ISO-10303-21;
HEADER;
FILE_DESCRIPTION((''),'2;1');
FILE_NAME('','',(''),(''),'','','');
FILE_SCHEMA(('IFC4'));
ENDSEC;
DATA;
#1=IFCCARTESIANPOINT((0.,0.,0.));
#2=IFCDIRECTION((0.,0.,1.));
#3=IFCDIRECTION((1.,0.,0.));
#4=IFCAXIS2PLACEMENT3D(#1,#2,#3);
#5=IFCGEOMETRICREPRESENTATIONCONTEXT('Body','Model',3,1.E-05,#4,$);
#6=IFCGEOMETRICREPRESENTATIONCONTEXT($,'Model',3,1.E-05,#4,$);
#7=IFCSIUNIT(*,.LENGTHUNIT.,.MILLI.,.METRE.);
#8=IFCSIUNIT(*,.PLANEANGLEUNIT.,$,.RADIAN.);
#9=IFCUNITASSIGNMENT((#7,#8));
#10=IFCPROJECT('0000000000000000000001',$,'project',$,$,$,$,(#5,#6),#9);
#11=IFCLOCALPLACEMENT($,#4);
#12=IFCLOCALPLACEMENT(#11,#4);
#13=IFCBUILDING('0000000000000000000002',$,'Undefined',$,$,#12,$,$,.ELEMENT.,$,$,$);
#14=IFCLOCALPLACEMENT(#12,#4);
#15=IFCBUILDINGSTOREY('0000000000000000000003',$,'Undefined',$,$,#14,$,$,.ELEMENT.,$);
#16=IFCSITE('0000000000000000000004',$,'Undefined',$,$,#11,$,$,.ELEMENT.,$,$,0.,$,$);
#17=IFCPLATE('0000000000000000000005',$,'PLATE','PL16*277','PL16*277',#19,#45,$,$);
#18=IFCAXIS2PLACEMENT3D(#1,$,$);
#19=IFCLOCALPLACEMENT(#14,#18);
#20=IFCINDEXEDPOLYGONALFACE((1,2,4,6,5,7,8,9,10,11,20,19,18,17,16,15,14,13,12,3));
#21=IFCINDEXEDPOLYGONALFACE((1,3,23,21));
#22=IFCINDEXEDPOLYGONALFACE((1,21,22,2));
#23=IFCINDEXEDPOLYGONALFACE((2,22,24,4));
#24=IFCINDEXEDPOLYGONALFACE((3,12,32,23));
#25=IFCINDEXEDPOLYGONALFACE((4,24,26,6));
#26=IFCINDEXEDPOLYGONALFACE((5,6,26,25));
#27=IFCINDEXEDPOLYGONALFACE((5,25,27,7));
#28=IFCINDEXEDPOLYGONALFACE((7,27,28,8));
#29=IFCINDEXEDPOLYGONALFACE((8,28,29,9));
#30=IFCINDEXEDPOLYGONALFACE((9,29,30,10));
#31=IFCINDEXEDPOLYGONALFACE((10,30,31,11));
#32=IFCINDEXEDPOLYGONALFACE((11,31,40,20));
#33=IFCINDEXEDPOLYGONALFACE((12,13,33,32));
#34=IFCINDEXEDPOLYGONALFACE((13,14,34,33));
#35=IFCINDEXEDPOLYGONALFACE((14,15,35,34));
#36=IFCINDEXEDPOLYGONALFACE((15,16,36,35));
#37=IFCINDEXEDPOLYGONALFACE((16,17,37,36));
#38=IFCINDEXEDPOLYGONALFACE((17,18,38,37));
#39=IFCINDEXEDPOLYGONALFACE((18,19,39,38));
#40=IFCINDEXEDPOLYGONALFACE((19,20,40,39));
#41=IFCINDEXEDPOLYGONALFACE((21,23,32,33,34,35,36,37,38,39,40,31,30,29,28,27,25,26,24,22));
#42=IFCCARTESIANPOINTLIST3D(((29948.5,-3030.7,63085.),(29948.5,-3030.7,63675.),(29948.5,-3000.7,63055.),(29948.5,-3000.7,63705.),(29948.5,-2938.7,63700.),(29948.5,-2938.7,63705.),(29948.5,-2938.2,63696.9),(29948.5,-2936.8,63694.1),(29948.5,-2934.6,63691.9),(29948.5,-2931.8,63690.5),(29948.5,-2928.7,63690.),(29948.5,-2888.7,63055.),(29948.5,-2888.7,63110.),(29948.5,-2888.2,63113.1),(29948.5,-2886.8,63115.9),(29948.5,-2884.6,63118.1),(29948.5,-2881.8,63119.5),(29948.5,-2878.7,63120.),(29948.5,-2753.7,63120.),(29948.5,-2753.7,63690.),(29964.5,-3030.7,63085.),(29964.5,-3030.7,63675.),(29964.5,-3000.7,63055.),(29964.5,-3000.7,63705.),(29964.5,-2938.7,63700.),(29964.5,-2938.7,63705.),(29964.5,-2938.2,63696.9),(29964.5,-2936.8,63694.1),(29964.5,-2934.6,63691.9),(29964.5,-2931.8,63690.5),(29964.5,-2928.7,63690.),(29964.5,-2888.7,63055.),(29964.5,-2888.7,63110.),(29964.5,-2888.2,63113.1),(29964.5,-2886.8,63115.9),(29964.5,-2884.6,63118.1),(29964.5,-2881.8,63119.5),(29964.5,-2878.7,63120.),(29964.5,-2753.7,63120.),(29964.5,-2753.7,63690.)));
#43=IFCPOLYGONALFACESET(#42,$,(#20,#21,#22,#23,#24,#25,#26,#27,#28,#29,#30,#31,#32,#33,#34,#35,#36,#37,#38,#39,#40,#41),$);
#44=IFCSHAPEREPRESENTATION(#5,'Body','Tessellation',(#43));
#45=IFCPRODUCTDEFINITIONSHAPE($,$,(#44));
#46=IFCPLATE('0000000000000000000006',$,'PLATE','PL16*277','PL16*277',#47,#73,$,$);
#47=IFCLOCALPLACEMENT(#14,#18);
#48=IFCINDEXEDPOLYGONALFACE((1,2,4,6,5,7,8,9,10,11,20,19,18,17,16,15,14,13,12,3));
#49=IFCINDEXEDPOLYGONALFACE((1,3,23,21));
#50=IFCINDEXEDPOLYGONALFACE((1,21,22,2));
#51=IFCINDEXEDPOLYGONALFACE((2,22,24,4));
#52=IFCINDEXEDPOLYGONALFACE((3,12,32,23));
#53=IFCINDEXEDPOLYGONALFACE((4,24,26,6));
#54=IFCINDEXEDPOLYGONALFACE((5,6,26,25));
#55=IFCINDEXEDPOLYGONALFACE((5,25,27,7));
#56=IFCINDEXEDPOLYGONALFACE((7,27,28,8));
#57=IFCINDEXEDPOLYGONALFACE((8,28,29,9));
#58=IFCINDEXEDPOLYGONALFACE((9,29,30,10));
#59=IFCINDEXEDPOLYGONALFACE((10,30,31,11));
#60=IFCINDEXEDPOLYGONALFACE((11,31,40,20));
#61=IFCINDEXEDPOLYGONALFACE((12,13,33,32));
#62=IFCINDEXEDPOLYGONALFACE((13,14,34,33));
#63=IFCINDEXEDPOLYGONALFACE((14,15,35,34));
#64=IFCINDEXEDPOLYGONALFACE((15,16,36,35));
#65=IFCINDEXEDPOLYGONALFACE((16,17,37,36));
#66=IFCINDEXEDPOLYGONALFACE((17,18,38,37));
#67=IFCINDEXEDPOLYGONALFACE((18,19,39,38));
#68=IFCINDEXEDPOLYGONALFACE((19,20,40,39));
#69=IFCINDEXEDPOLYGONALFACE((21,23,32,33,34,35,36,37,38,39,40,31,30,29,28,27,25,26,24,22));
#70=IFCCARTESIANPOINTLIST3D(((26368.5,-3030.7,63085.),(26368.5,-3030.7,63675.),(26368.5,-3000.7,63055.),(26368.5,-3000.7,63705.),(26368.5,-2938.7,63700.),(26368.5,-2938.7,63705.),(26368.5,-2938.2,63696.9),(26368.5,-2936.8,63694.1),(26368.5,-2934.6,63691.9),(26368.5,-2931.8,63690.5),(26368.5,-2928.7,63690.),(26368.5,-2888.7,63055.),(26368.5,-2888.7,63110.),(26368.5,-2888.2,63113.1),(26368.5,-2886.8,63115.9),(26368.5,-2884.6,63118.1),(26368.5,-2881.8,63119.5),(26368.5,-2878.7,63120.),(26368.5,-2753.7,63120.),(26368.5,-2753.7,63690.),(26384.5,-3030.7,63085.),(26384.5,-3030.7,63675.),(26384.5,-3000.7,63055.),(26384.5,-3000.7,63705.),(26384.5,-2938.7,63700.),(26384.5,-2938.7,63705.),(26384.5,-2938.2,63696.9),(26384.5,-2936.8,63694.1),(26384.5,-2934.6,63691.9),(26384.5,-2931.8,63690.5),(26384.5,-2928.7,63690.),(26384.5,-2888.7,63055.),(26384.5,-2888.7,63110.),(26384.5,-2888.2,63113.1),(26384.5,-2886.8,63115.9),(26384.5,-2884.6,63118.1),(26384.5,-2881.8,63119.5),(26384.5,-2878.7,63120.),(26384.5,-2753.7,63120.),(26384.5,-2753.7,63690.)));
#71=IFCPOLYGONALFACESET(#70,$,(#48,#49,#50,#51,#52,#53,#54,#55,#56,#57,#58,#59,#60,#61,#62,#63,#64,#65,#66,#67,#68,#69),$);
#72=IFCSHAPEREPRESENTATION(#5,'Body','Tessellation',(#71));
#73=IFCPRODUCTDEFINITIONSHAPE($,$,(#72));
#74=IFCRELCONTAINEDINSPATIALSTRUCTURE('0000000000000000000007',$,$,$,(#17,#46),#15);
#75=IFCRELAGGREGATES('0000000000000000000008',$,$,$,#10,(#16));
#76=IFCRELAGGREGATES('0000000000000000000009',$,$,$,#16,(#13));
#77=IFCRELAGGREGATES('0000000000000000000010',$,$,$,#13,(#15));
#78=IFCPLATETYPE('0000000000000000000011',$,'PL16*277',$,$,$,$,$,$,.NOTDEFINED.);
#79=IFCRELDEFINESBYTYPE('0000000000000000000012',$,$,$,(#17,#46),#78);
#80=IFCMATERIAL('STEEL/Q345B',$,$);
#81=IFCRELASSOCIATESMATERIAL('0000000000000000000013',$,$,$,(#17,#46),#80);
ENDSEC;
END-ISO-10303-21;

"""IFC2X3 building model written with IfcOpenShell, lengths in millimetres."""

from ifc_helpers import new_model, si_unit, frame, origin_with_axes, place, context, project, spatial, polyline, outline, extrude, material, type_object, element, save


model = new_model("IFC2X3")

# Units and contexts
model_context_1 = context("Model", 3, precision=1e-05, world=origin_with_axes(), identifier="Body")
model_context_2 = context("Model", 3, precision=1e-05, world=origin_with_axes())
ifc_project = project(units=[si_unit("LENGTHUNIT", "METRE", prefix="MILLI"), si_unit("PLANEANGLEUNIT", "RADIAN")], contexts=[model_context_1, model_context_2])

# Site, building, storey
site_placement = place(None, origin_with_axes())
site = spatial("IfcSite", under=ifc_project, at=site_placement, Name="Undefined", CompositionType="ELEMENT", RefElevation=0.0)
building_placement = place(site_placement, origin_with_axes())
building = spatial("IfcBuilding", under=site, at=building_placement, Name="Undefined", CompositionType="ELEMENT")
storey_placement = place(building_placement, origin_with_axes())
storey = spatial("IfcBuildingStorey", under=building, at=storey_placement, Name="Undefined", CompositionType="ELEMENT")

# Shared definitions
ifc_material_1 = material(Name="STEEL/Q345B")

# Plates
plate_type_1 = type_object("IfcPlateType", Name="PL16*277", PredefinedType="NOTDEFINED")
for number, where, z_axis, x_axis, name in (
    (1, (29956.5, -3030.7, 63085.0), (1.0, 0.0, 0.0), (0.0, 0.707107, -0.707107), "PLATE"),
    (2, (26376.5, -3030.7, 63085.0), (1.0, 0.0, 0.0), (0.0, 0.707107, -0.707107), "PLATE"),
):
    element("IfcPlate", number, at=place(storey_placement, frame(where, z_axis=z_axis, x_axis=x_axis)), inside=storey, type_object=plate_type_1, material=ifc_material_1, Name=name, Description="PL16*277", ObjectType="PL16*277", context=model_context_1, shape_type="SweptSolid", body=[
        extrude(outline(polyline([(0.0, 0.0), (42.4, 0.0), (121.6, 79.2), (82.7, 118.1), (80.9, 120.6), (79.9, 123.6), (79.9, 126.7), (80.9, 129.7), (82.7, 132.2), (171.1, 220.6), (-231.9, 623.7), (-355.7, 499.9), (-358.2, 498.1), (-361.2, 497.1), (-364.3, 497.1), (-367.3, 498.1), (-369.8, 499.9), (-373.4, 503.5), (-417.2, 459.6), (-417.2, 417.2), (0.0, 0.0)])), frame((0.0, 0.0, -8.0), z_axis=(0.0, 0.0, 1.0), x_axis=(1.0, 0.0, 0.0)), (0.0, 0.0, 1.0), 16.0),
    ])

save(model, "model.ifc")
